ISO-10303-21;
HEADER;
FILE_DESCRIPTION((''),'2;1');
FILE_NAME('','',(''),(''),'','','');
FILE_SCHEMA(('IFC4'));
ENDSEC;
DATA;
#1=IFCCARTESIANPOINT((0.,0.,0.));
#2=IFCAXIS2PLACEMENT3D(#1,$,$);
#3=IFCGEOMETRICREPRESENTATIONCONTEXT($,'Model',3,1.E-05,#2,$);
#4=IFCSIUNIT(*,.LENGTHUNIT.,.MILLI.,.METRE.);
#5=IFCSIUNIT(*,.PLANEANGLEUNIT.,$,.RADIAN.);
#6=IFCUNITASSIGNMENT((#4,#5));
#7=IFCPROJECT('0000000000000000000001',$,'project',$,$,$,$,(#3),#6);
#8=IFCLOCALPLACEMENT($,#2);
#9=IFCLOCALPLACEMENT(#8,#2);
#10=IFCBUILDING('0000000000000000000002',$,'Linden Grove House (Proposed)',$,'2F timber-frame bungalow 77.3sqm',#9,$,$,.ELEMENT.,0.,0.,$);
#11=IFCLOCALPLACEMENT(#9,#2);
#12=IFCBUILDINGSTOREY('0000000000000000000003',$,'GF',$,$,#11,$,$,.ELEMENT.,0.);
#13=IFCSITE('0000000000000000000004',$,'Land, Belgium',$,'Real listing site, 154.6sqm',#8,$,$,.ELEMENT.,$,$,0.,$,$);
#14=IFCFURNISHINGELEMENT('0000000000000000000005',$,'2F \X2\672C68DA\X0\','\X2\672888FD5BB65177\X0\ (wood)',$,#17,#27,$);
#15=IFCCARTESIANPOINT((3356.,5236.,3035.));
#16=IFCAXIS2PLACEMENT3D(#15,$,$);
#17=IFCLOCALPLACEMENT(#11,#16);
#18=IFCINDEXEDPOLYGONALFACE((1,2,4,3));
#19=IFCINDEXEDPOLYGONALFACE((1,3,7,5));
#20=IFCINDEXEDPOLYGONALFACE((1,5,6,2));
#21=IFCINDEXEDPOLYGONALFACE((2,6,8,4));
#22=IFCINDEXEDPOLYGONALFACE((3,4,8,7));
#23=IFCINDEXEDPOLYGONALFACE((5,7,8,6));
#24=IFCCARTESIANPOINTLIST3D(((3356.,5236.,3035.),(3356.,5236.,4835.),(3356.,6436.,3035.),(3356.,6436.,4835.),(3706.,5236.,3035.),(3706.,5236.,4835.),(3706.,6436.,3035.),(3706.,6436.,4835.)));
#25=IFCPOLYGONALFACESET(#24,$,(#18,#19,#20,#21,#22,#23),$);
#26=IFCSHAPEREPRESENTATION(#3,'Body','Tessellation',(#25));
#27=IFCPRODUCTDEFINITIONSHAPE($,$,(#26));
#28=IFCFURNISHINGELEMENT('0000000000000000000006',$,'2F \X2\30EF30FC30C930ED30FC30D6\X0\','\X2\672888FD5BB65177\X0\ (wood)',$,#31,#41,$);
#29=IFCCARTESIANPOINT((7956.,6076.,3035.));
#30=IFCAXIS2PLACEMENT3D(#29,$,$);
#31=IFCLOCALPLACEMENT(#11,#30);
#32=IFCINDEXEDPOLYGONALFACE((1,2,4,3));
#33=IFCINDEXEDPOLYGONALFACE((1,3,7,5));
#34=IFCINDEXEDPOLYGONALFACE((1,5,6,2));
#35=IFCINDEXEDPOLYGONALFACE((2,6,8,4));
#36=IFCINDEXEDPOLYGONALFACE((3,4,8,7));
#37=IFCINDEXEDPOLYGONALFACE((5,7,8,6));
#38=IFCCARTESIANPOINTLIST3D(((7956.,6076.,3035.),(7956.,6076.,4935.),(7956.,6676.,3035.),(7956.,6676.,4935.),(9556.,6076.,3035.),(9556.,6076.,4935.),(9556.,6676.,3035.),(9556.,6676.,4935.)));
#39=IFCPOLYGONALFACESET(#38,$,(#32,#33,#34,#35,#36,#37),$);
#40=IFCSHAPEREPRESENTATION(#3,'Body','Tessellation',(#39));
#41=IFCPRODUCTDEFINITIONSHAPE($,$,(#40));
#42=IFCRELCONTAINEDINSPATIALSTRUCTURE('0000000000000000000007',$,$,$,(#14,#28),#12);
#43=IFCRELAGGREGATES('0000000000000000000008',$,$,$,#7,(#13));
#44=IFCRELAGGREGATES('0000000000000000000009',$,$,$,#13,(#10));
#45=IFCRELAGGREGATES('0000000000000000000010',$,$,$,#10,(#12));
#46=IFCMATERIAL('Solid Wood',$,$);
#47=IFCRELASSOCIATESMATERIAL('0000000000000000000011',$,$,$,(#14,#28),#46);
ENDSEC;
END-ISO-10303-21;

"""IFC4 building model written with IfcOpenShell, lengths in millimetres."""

from ifc_helpers import new_model, si_unit, frame, frame_2d, origin, place, context, project, spatial, rectangle, extrude, material, element, save


model = new_model("IFC4")

# Units and contexts
model_context = context("Model", 3, precision=1e-05, world=origin())
ifc_project = project(units=[si_unit("LENGTHUNIT", "METRE", prefix="MILLI"), si_unit("PLANEANGLEUNIT", "RADIAN")], contexts=[model_context])

# Site, building, storey
site_placement = place(None, origin())
site = spatial("IfcSite", under=ifc_project, at=site_placement, Name="Land, Belgium", ObjectType="Real listing site, 154.6sqm", CompositionType="ELEMENT", RefElevation=0.0)
building_placement = place(site_placement, origin())
building = spatial("IfcBuilding", under=site, at=building_placement, Name="Linden Grove House (Proposed)", ObjectType="2F timber-frame bungalow 77.3sqm", CompositionType="ELEMENT", ElevationOfRefHeight=0.0, ElevationOfTerrain=0.0)
storey_placement = place(building_placement, origin())
storey = spatial("IfcBuildingStorey", under=building, at=storey_placement, Name="GF", CompositionType="ELEMENT", Elevation=0.0)

# Shared definitions
ifc_material_1 = material(Name="Solid Wood")

# Furnishing elements
furnishing_1_placement = place(storey_placement, frame((3356.0, 5236.0, 3035.0)))
element("IfcFurnishingElement", 1, at=furnishing_1_placement, inside=storey, material=ifc_material_1, Name="2F 本棚", Description="木製家具 (wood)", context=model_context, shape_type="SweptSolid", body=[
    extrude(rectangle(XDim=350.0, YDim=1200.0, at=frame_2d((175.0, 600.0))), frame((3356.0, 5236.0, 3035.0)), (0.0, 0.0, 1.0), 1800.0),
])
furnishing_2_placement = place(storey_placement, frame((7956.0, 6076.0, 3035.0)))
element("IfcFurnishingElement", 2, at=furnishing_2_placement, inside=storey, material=ifc_material_1, Name="2F ワードローブ", Description="木製家具 (wood)", context=model_context, shape_type="SweptSolid", body=[
    extrude(rectangle(XDim=1600.0, YDim=600.0, at=frame_2d((800.0, 300.0))), frame((7956.0, 6076.0, 3035.0)), (0.0, 0.0, 1.0), 1900.0),
])

save(model, "model.ifc")
